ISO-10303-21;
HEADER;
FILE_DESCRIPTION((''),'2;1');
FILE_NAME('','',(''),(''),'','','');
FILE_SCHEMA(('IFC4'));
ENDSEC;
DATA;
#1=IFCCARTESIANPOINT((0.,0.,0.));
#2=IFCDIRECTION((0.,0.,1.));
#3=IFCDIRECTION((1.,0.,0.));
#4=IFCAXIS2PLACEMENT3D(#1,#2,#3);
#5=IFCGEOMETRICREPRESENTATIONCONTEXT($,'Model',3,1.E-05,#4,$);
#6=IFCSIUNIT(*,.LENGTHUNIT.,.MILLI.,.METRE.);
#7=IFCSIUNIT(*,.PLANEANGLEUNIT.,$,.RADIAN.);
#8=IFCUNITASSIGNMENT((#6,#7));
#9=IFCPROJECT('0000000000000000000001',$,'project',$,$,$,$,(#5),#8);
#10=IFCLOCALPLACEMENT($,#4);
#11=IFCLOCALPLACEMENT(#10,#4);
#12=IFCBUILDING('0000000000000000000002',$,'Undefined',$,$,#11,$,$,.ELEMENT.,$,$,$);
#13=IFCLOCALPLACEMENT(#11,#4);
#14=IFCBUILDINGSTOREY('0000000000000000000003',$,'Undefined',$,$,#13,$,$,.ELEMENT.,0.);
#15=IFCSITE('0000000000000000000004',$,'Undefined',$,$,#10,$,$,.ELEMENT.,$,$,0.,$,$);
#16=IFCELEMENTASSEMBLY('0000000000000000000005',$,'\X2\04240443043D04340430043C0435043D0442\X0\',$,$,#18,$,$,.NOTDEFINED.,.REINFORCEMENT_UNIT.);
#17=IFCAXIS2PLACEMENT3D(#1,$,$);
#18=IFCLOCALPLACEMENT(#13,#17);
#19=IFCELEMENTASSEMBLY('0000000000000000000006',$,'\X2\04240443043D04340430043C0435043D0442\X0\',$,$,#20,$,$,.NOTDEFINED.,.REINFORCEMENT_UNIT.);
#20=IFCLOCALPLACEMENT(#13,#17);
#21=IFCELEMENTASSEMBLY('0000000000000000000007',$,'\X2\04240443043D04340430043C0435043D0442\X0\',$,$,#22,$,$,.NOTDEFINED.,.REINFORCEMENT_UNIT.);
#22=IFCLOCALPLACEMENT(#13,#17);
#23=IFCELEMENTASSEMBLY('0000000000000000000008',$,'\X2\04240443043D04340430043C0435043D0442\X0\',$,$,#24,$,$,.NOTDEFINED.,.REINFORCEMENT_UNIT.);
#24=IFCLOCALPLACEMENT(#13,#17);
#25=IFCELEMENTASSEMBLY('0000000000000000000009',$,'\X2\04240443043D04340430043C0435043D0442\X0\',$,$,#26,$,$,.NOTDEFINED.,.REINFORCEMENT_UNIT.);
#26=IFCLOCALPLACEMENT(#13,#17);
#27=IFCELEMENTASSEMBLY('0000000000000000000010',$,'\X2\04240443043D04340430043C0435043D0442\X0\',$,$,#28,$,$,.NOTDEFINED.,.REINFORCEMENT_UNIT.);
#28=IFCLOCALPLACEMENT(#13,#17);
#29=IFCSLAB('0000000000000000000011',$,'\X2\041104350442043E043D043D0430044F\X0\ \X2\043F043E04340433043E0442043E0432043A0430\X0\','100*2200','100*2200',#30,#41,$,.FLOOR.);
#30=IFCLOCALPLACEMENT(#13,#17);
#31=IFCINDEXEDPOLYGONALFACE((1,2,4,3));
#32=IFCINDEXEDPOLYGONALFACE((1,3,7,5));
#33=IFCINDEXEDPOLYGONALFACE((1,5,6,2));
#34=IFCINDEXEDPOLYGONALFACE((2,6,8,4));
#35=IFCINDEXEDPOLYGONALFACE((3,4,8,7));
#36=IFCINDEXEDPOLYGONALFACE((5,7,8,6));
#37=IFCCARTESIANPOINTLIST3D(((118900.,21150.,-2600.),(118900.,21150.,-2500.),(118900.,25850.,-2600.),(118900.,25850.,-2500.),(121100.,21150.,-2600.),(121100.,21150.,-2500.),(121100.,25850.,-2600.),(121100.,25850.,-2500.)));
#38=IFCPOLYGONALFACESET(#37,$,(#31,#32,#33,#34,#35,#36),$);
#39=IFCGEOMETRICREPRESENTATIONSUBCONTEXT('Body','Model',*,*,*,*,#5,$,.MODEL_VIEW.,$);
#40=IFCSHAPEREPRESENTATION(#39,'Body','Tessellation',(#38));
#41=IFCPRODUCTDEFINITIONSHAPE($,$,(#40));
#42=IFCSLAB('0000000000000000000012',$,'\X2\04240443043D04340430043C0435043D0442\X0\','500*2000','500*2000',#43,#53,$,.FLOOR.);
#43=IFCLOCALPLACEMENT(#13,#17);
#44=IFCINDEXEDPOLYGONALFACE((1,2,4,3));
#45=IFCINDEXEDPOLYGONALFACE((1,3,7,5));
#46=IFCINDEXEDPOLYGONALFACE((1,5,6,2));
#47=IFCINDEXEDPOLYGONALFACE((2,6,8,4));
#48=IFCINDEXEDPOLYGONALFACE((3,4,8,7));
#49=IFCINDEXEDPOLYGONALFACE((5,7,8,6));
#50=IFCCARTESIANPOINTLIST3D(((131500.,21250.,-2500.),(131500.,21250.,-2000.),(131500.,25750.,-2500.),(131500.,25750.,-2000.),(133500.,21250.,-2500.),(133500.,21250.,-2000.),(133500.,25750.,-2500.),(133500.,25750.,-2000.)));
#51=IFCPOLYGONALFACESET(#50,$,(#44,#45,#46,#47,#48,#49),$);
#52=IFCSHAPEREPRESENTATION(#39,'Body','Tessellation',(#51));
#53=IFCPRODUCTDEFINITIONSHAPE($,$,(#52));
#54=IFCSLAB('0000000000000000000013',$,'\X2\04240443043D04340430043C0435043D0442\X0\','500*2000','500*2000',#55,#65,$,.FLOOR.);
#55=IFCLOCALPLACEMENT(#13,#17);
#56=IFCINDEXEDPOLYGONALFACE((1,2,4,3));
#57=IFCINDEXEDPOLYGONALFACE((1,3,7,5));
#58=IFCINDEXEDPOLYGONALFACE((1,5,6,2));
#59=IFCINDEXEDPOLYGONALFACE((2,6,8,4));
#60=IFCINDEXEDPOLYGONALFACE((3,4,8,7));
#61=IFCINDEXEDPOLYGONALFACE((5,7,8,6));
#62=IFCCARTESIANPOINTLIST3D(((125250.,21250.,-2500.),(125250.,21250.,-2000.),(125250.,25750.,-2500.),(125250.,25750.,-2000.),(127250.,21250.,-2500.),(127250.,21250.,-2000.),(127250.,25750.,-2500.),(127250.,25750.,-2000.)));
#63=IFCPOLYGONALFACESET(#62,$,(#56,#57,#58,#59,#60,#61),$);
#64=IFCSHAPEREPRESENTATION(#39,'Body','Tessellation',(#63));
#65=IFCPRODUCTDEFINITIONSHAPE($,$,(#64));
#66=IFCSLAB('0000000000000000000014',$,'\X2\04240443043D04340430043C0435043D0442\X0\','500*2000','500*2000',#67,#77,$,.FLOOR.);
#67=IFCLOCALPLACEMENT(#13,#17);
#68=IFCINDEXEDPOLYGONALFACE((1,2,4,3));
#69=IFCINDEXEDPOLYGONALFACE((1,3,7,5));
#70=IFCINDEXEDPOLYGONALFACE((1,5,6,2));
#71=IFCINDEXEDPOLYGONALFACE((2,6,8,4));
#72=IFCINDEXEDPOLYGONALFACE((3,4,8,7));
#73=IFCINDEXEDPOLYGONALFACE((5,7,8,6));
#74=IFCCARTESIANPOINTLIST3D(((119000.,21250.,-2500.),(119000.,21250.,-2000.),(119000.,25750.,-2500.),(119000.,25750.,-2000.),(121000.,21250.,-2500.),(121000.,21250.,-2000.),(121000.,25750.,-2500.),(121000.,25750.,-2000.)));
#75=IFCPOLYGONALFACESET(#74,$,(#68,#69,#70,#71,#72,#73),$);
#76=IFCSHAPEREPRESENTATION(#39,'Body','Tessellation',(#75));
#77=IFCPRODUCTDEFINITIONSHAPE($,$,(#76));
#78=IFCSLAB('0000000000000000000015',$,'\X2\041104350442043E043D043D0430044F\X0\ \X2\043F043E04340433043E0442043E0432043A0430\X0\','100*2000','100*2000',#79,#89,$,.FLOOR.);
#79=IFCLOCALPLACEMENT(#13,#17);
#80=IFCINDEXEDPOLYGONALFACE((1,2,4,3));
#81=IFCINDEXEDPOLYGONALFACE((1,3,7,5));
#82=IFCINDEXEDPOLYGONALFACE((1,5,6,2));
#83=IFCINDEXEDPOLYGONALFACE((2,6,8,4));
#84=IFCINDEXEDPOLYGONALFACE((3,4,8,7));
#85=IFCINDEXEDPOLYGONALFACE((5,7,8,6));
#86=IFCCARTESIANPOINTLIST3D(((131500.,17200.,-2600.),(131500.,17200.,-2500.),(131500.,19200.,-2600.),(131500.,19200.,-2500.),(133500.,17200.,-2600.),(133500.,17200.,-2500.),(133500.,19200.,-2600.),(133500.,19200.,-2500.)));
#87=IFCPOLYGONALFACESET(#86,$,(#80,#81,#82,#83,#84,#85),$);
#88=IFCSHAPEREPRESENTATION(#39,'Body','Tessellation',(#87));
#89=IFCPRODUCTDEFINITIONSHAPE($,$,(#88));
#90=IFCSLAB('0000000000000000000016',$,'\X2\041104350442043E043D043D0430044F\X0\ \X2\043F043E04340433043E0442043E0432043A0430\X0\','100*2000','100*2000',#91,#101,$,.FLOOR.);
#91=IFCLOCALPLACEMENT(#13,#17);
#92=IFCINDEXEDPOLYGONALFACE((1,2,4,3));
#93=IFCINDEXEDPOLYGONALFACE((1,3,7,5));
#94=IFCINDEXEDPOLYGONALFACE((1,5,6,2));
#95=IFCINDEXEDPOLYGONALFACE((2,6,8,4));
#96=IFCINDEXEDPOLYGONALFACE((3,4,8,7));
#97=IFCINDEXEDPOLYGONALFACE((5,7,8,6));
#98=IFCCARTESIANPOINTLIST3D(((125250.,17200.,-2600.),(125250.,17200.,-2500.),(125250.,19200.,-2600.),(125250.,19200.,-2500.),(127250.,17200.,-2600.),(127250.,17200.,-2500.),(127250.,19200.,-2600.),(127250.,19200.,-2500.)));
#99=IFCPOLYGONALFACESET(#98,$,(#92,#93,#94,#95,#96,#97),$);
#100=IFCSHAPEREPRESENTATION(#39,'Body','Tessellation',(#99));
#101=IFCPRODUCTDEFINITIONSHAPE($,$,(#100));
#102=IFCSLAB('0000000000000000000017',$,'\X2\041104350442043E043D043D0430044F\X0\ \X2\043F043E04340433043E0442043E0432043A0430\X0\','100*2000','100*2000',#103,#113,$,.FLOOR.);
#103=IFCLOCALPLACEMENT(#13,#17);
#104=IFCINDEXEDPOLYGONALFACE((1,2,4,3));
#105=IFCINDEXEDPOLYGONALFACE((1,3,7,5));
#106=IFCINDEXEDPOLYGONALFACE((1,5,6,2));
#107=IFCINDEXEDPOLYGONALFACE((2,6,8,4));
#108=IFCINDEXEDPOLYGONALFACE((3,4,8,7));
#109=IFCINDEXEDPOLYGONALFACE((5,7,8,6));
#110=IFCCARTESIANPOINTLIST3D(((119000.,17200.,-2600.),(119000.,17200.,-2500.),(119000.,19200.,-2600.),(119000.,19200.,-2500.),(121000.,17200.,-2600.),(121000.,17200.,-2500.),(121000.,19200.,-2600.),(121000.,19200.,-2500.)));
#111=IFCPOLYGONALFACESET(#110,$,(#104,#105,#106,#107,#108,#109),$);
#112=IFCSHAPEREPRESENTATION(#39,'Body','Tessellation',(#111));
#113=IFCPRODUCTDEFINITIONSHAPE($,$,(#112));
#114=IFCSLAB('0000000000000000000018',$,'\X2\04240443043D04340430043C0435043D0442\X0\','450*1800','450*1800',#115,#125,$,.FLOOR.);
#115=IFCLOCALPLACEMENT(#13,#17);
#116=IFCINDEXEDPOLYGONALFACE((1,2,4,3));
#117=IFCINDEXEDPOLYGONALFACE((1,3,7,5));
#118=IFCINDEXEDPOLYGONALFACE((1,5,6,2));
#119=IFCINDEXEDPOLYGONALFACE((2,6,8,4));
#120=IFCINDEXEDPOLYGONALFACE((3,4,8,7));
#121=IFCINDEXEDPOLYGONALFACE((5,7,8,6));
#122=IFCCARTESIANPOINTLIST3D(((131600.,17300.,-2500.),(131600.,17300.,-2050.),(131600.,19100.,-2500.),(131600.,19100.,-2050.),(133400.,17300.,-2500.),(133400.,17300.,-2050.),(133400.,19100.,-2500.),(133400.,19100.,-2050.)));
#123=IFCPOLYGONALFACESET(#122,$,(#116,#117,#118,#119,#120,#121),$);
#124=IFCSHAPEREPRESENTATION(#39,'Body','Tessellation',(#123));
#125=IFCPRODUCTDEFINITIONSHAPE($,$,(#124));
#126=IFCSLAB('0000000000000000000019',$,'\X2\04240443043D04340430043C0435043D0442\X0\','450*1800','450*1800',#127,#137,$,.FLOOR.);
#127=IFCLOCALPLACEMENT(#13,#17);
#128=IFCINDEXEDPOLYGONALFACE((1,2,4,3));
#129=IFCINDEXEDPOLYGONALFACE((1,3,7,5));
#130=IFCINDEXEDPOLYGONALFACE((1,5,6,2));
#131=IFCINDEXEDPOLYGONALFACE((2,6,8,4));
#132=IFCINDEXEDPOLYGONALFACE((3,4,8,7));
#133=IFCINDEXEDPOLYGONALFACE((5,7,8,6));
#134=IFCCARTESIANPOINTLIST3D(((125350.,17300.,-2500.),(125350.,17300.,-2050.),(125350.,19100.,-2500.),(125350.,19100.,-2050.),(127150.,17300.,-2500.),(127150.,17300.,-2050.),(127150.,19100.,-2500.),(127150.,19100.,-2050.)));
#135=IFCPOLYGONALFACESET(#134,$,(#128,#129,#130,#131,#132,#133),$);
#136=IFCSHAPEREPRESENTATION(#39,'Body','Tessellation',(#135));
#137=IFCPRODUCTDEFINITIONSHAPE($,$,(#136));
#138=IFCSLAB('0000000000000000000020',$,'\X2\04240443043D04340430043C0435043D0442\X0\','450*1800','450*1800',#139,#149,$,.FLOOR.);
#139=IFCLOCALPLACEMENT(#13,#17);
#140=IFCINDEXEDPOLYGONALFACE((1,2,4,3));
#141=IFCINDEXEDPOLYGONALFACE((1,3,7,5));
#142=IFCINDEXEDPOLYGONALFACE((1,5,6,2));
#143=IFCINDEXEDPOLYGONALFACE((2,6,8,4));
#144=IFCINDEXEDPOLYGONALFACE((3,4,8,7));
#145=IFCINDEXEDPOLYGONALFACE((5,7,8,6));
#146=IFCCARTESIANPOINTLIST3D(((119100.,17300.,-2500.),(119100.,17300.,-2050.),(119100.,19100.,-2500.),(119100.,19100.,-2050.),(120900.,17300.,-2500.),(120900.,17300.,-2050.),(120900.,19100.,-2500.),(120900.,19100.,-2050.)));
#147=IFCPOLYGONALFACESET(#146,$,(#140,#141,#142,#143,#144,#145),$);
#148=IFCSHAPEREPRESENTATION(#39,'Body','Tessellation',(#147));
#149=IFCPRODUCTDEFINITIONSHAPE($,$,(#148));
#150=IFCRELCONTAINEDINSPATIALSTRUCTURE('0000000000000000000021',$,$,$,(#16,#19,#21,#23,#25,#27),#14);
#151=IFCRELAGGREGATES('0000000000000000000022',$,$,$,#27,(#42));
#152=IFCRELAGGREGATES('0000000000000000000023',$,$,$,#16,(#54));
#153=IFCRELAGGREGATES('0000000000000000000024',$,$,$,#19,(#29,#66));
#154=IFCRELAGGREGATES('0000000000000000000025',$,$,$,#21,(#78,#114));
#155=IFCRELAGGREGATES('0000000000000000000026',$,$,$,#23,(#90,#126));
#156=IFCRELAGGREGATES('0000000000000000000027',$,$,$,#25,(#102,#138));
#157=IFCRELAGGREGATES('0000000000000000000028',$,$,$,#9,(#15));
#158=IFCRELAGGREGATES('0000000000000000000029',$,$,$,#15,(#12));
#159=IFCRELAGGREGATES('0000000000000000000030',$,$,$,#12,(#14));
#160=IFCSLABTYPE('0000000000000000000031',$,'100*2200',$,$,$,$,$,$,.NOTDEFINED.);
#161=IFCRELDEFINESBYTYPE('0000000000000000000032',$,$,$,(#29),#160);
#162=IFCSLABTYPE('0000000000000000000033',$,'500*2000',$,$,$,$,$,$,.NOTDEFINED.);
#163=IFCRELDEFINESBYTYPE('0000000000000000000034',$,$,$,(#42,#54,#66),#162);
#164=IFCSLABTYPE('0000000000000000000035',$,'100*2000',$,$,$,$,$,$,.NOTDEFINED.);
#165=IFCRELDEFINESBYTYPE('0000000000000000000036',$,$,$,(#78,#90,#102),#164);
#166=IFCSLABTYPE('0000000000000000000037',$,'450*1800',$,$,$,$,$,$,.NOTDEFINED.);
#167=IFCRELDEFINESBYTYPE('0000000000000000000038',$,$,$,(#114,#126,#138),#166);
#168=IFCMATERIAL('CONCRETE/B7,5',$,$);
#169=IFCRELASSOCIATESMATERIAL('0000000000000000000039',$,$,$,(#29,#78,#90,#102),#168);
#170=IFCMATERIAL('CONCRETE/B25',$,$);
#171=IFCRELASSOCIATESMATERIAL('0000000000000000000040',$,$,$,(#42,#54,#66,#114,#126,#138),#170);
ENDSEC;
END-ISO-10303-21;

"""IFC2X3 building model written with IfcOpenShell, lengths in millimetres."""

from ifc_helpers import new_model, si_unit, frame, origin_with_axes, place, context, subcontext, project, spatial, polyline, outline, extrude, material, type_object, element, aggregate, save


model = new_model("IFC2X3")

# Units and contexts
model_context = context("Model", 3, precision=1e-05, world=origin_with_axes())
body_context = subcontext(model_context, "Body", "Model", "MODEL_VIEW")
ifc_project = project(units=[si_unit("LENGTHUNIT", "METRE", prefix="MILLI"), si_unit("PLANEANGLEUNIT", "RADIAN")], contexts=[model_context])

# Site, building, storey
site_placement = place(None, origin_with_axes())
site = spatial("IfcSite", under=ifc_project, at=site_placement, Name="Undefined", CompositionType="ELEMENT", RefElevation=0.0)
building_placement = place(site_placement, origin_with_axes())
building = spatial("IfcBuilding", under=site, at=building_placement, Name="Undefined", CompositionType="ELEMENT")
storey_placement = place(building_placement, origin_with_axes())
storey = spatial("IfcBuildingStorey", under=building, at=storey_placement, Name="Undefined", CompositionType="ELEMENT", Elevation=0.0)

# Element assemblies
assembly_1_placement = place(storey_placement, origin_with_axes())
assembly_1 = element("IfcElementAssembly", 1, at=assembly_1_placement, inside=storey, Name="Фундамент", AssemblyPlace="NOTDEFINED", PredefinedType="REINFORCEMENT_UNIT")
ifc_material_1 = material(Name="CONCRETE/B25")
assembly_2_placement = place(storey_placement, origin_with_axes())
assembly_2 = element("IfcElementAssembly", 2, at=assembly_2_placement, inside=storey, Name="Фундамент", AssemblyPlace="NOTDEFINED", PredefinedType="REINFORCEMENT_UNIT")

# Element assemblies
assembly_3_placement = place(storey_placement, origin_with_axes())
assembly_3 = element("IfcElementAssembly", 3, at=assembly_3_placement, inside=storey, Name="Фундамент", AssemblyPlace="NOTDEFINED", PredefinedType="REINFORCEMENT_UNIT")
assembly_4_placement = place(storey_placement, origin_with_axes())
assembly_4 = element("IfcElementAssembly", 4, at=assembly_4_placement, inside=storey, Name="Фундамент", AssemblyPlace="NOTDEFINED", PredefinedType="REINFORCEMENT_UNIT")
assembly_5_placement = place(storey_placement, origin_with_axes())
assembly_5 = element("IfcElementAssembly", 5, at=assembly_5_placement, inside=storey, Name="Фундамент", AssemblyPlace="NOTDEFINED", PredefinedType="REINFORCEMENT_UNIT")
assembly_6_placement = place(storey_placement, origin_with_axes())
assembly_6 = element("IfcElementAssembly", 6, at=assembly_6_placement, inside=storey, Name="Фундамент", AssemblyPlace="NOTDEFINED", PredefinedType="REINFORCEMENT_UNIT")

# Slabs
ifc_material_2 = material(Name="CONCRETE/B7,5")
slab_type_1 = type_object("IfcSlabType", Name="100*2200", PredefinedType="NOTDEFINED")
slab_1_placement = place(assembly_2_placement, frame((118900.0, 25850.0, -2550.0), z_axis=(0.0, 0.0, 1.0), x_axis=(0.0, -1.0, 0.0)))
slab_1 = element("IfcSlab", 7, at=slab_1_placement, type_object=slab_type_1, material=ifc_material_2, Name="Бетонная подготовка", Description="100*2200", ObjectType="100*2200", PredefinedType="FLOOR", context=body_context, shape_type="SweptSolid", body=[
    extrude(outline(polyline([(0.0, 0.0), (4700.0, 0.0), (4700.0, 2200.0), (0.0, 2200.0), (0.0, 0.0)])), frame((0.0, 0.0, -50.0), z_axis=(0.0, 0.0, 1.0), x_axis=(1.0, 0.0, 0.0)), (0.0, 0.0, 1.0), 100.0),
])
slab_type_2 = type_object("IfcSlabType", Name="500*2000", PredefinedType="NOTDEFINED")
slab_2_placement = place(assembly_6_placement, frame((131500.0, 25750.0, -2250.0), z_axis=(0.0, 0.0, 1.0), x_axis=(0.0, -1.0, 0.0)))
slab_2 = element("IfcSlab", 8, at=slab_2_placement, type_object=slab_type_2, material=ifc_material_1, Name="Фундамент", Description="500*2000", ObjectType="500*2000", PredefinedType="FLOOR", context=body_context, shape_type="SweptSolid", body=[
    extrude(outline(polyline([(0.0, 0.0), (4500.0, 0.0), (4500.0, 2000.0), (0.0, 2000.0), (0.0, 0.0)])), frame((0.0, 0.0, -250.0), z_axis=(0.0, 0.0, 1.0), x_axis=(1.0, 0.0, 0.0)), (0.0, 0.0, 1.0), 500.0),
])
aggregate(assembly_6, [slab_2])
slab_3_placement = place(assembly_1_placement, frame((125250.0, 25750.0, -2250.0), z_axis=(0.0, 0.0, 1.0), x_axis=(0.0, -1.0, 0.0)))
slab_3 = element("IfcSlab", 9, at=slab_3_placement, type_object=slab_type_2, material=ifc_material_1, Name="Фундамент", Description="500*2000", ObjectType="500*2000", PredefinedType="FLOOR", context=body_context, shape_type="SweptSolid", body=[
    extrude(outline(polyline([(0.0, 0.0), (4500.0, 0.0), (4500.0, 2000.0), (0.0, 2000.0), (0.0, 0.0)])), frame((0.0, 0.0, -250.0), z_axis=(0.0, 0.0, 1.0), x_axis=(1.0, 0.0, 0.0)), (0.0, 0.0, 1.0), 500.0),
])
aggregate(assembly_1, [slab_3])
slab_4_placement = place(assembly_2_placement, frame((119000.0, 25750.0, -2250.0), z_axis=(0.0, 0.0, 1.0), x_axis=(0.0, -1.0, 0.0)))
slab_4 = element("IfcSlab", 10, at=slab_4_placement, type_object=slab_type_2, material=ifc_material_1, Name="Фундамент", Description="500*2000", ObjectType="500*2000", PredefinedType="FLOOR", context=body_context, shape_type="SweptSolid", body=[
    extrude(outline(polyline([(0.0, 0.0), (4500.0, 0.0), (4500.0, 2000.0), (0.0, 2000.0), (0.0, 0.0)])), frame((0.0, 0.0, -250.0), z_axis=(0.0, 0.0, 1.0), x_axis=(1.0, 0.0, 0.0)), (0.0, 0.0, 1.0), 500.0),
])
aggregate(assembly_2, [slab_1, slab_4])
slab_type_3 = type_object("IfcSlabType", Name="100*2000", PredefinedType="NOTDEFINED")
slab_5_placement = place(assembly_3_placement, frame((131500.0, 19200.0, -2550.0), z_axis=(0.0, 0.0, 1.0), x_axis=(0.0, -1.0, 0.0)))
slab_5 = element("IfcSlab", 11, at=slab_5_placement, type_object=slab_type_3, material=ifc_material_2, Name="Бетонная подготовка", Description="100*2000", ObjectType="100*2000", PredefinedType="FLOOR", context=body_context, shape_type="SweptSolid", body=[
    extrude(outline(polyline([(0.0, 0.0), (2000.0, 0.0), (2000.0, 2000.0), (0.0, 2000.0), (0.0, 0.0)])), frame((0.0, 0.0, -50.0), z_axis=(0.0, 0.0, 1.0), x_axis=(1.0, 0.0, 0.0)), (0.0, 0.0, 1.0), 100.0),
])
slab_6_placement = place(assembly_4_placement, frame((125250.0, 19200.0, -2550.0), z_axis=(0.0, 0.0, 1.0), x_axis=(0.0, -1.0, 0.0)))
slab_6 = element("IfcSlab", 12, at=slab_6_placement, type_object=slab_type_3, material=ifc_material_2, Name="Бетонная подготовка", Description="100*2000", ObjectType="100*2000", PredefinedType="FLOOR", context=body_context, shape_type="SweptSolid", body=[
    extrude(outline(polyline([(0.0, 0.0), (2000.0, 0.0), (2000.0, 2000.0), (0.0, 2000.0), (0.0, 0.0)])), frame((0.0, 0.0, -50.0), z_axis=(0.0, 0.0, 1.0), x_axis=(1.0, 0.0, 0.0)), (0.0, 0.0, 1.0), 100.0),
])
slab_7_placement = place(assembly_5_placement, frame((119000.0, 19200.0, -2550.0), z_axis=(0.0, 0.0, 1.0), x_axis=(0.0, -1.0, 0.0)))
slab_7 = element("IfcSlab", 13, at=slab_7_placement, type_object=slab_type_3, material=ifc_material_2, Name="Бетонная подготовка", Description="100*2000", ObjectType="100*2000", PredefinedType="FLOOR", context=body_context, shape_type="SweptSolid", body=[
    extrude(outline(polyline([(0.0, 0.0), (2000.0, 0.0), (2000.0, 2000.0), (0.0, 2000.0), (0.0, 0.0)])), frame((0.0, 0.0, -50.0), z_axis=(0.0, 0.0, 1.0), x_axis=(1.0, 0.0, 0.0)), (0.0, 0.0, 1.0), 100.0),
])
slab_type_4 = type_object("IfcSlabType", Name="450*1800", PredefinedType="NOTDEFINED")
slab_8_placement = place(assembly_3_placement, frame((131600.0, 19100.0, -2275.0), z_axis=(0.0, 0.0, 1.0), x_axis=(0.0, -1.0, 0.0)))
slab_8 = element("IfcSlab", 14, at=slab_8_placement, type_object=slab_type_4, material=ifc_material_1, Name="Фундамент", Description="450*1800", ObjectType="450*1800", PredefinedType="FLOOR", context=body_context, shape_type="SweptSolid", body=[
    extrude(outline(polyline([(0.0, 0.0), (1800.0, 0.0), (1800.0, 1800.0), (0.0, 1800.0), (0.0, 0.0)])), frame((0.0, 0.0, -225.0), z_axis=(0.0, 0.0, 1.0), x_axis=(1.0, 0.0, 0.0)), (0.0, 0.0, 1.0), 450.0),
])
aggregate(assembly_3, [slab_5, slab_8])
slab_9_placement = place(assembly_4_placement, frame((125350.0, 19100.0, -2275.0), z_axis=(0.0, 0.0, 1.0), x_axis=(0.0, -1.0, 0.0)))
slab_9 = element("IfcSlab", 15, at=slab_9_placement, type_object=slab_type_4, material=ifc_material_1, Name="Фундамент", Description="450*1800", ObjectType="450*1800", PredefinedType="FLOOR", context=body_context, shape_type="SweptSolid", body=[
    extrude(outline(polyline([(0.0, 0.0), (1800.0, 0.0), (1800.0, 1800.0), (0.0, 1800.0), (0.0, 0.0)])), frame((0.0, 0.0, -225.0), z_axis=(0.0, 0.0, 1.0), x_axis=(1.0, 0.0, 0.0)), (0.0, 0.0, 1.0), 450.0),
])
aggregate(assembly_4, [slab_6, slab_9])
slab_10_placement = place(assembly_5_placement, frame((119100.0, 19100.0, -2275.0), z_axis=(0.0, 0.0, 1.0), x_axis=(0.0, -1.0, 0.0)))
slab_10 = element("IfcSlab", 16, at=slab_10_placement, type_object=slab_type_4, material=ifc_material_1, Name="Фундамент", Description="450*1800", ObjectType="450*1800", PredefinedType="FLOOR", context=body_context, shape_type="SweptSolid", body=[
    extrude(outline(polyline([(0.0, 0.0), (1800.0, 0.0), (1800.0, 1800.0), (0.0, 1800.0), (0.0, 0.0)])), frame((0.0, 0.0, -225.0), z_axis=(0.0, 0.0, 1.0), x_axis=(1.0, 0.0, 0.0)), (0.0, 0.0, 1.0), 450.0),
])
aggregate(assembly_5, [slab_7, slab_10])

save(model, "model.ifc")
